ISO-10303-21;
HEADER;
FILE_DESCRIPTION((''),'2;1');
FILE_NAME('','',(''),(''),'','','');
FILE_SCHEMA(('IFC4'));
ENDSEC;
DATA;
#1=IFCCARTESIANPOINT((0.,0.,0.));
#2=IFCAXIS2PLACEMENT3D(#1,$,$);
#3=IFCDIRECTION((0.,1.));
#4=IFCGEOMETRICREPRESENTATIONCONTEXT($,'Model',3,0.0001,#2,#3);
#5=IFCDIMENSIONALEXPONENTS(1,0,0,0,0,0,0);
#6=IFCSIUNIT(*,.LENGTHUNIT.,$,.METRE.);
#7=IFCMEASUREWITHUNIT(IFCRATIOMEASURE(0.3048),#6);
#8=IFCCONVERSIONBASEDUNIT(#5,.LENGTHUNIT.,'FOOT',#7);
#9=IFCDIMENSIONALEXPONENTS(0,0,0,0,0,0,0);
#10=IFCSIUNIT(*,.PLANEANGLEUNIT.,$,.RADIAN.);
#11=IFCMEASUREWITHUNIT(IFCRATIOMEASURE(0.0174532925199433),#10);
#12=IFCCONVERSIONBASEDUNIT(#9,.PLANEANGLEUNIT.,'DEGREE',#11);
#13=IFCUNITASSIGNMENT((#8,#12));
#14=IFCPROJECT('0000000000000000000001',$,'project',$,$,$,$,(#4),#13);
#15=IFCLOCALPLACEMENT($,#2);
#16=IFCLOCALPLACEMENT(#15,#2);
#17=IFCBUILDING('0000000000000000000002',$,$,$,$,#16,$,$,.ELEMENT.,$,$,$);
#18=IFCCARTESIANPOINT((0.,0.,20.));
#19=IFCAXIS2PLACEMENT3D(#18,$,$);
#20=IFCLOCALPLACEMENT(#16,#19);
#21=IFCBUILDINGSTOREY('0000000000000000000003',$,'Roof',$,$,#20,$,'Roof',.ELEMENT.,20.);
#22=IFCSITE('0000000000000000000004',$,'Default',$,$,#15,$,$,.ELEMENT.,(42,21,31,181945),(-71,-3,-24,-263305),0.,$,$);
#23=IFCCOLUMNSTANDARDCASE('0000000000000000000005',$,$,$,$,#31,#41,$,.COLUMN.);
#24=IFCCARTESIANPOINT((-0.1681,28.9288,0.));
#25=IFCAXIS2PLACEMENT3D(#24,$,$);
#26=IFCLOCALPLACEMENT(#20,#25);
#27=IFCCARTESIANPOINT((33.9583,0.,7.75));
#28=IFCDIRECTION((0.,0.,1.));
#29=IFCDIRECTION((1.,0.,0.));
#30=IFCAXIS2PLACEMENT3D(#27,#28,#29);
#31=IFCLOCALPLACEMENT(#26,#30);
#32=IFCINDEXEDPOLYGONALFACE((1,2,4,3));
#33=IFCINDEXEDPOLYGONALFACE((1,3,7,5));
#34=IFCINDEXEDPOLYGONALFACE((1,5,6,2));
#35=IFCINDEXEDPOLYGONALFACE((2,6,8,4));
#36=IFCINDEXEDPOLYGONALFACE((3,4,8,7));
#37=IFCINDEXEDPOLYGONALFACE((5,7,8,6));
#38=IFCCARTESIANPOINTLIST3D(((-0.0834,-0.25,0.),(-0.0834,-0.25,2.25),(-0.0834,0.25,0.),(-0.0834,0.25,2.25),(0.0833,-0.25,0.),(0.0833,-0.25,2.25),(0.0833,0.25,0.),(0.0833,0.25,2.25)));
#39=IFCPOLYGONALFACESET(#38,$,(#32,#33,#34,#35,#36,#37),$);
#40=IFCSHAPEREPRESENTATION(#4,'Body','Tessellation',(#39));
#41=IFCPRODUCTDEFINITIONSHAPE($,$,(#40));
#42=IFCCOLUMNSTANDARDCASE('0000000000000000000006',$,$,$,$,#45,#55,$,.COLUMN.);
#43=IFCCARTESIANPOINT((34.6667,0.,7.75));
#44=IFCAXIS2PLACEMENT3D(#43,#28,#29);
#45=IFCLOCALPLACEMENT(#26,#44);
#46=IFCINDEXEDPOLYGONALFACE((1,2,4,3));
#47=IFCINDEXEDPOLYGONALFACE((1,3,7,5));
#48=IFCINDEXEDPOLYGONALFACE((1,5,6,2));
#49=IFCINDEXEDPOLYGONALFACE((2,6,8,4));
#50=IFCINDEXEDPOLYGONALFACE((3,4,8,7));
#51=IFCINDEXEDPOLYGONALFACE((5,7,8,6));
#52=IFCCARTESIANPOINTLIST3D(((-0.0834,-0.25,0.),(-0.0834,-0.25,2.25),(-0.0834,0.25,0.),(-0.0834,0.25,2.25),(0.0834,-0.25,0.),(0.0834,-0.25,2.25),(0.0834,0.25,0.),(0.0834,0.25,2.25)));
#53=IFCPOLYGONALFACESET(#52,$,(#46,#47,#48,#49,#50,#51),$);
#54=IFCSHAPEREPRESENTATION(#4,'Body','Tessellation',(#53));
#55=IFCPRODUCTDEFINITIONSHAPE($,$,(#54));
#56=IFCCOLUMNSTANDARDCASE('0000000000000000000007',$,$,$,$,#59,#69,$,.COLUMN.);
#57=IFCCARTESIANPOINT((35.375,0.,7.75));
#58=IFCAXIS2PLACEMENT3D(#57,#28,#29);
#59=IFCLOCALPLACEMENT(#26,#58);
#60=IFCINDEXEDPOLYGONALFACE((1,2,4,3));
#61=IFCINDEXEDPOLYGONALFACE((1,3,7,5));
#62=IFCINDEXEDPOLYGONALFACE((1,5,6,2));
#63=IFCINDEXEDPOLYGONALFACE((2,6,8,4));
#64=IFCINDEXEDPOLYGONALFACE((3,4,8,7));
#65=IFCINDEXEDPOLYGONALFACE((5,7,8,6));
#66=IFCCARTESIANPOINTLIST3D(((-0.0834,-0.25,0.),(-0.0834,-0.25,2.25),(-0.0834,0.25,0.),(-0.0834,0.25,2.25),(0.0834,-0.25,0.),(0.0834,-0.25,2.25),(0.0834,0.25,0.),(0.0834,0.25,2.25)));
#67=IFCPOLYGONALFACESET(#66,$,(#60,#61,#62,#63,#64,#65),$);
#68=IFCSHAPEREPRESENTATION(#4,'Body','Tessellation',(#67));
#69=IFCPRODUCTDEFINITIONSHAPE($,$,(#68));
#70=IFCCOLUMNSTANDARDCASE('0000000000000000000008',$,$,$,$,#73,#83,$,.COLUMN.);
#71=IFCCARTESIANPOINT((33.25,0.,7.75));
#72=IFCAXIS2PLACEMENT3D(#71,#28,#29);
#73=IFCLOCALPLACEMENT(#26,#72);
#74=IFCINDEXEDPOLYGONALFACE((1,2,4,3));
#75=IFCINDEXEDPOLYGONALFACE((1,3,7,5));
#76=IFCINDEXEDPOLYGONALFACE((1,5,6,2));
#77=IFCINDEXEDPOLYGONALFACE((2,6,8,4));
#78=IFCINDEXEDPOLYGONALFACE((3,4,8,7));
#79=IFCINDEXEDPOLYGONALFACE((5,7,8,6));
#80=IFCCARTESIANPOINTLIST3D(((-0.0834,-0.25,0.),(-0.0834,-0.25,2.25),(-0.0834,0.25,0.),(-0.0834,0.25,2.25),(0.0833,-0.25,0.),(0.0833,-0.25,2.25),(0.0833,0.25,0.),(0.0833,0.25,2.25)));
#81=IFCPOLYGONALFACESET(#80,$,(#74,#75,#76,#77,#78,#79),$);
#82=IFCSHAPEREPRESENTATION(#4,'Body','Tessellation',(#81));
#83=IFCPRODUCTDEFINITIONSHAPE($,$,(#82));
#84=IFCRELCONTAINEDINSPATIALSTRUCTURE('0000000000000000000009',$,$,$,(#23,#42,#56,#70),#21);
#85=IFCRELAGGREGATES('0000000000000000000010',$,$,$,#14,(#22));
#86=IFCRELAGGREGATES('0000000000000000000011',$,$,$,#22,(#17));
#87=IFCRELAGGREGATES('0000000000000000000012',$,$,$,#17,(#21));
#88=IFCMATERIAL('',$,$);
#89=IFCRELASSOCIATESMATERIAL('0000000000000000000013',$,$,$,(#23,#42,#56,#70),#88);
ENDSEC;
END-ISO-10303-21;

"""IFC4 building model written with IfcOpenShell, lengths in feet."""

from ifc_helpers import new_model, entity, si_unit, converted_unit, direction, frame, origin, place, context, project, spatial, rectangle, extrude, material, element, save


model = new_model("IFC4")

# Units and contexts
model_context = context("Model", 3, precision=0.0001, world=origin(), true_north=direction((0.0, 1.0)))
ifc_project = project(units=[converted_unit("LENGTHUNIT", "FOOT", entity("IfcRatioMeasure", 0.3048), si_unit("LENGTHUNIT", "METRE"), dimensions=[1, 0, 0, 0, 0, 0, 0]), converted_unit("PLANEANGLEUNIT", "DEGREE", entity("IfcRatioMeasure", 0.0174532925199433), si_unit("PLANEANGLEUNIT", "RADIAN"), dimensions=[0, 0, 0, 0, 0, 0, 0])], contexts=[model_context])

# Site, building, storey
site_placement = place(None, origin())
site = spatial("IfcSite", under=ifc_project, at=site_placement, Name="Default", CompositionType="ELEMENT", RefLatitude=(42, 21, 31, 181945), RefLongitude=(-71, -3, -24, -263305), RefElevation=0.0)
building_placement = place(site_placement, origin())
building = spatial("IfcBuilding", under=site, at=building_placement, CompositionType="ELEMENT")
storey_placement = place(building_placement, frame((0.0, 0.0, 20.0)))
storey = spatial("IfcBuildingStorey", under=building, at=storey_placement, Name="Roof", LongName="Roof", CompositionType="ELEMENT", Elevation=20.0)

# Columns
ifc_material_1 = material(Name="")
placement = place(storey_placement, frame((-0.1681, 28.9288, 0.0)))
for number, where, z_axis, x_axis in (
    (1, (33.9583, 0.0, 7.75), (0.0, 0.0, 1.0), (1.0, 0.0, 0.0)),
    (2, (34.6667, 0.0, 7.75), (0.0, 0.0, 1.0), (1.0, 0.0, 0.0)),
    (3, (35.375, 0.0, 7.75), (0.0, 0.0, 1.0), (1.0, 0.0, 0.0)),
    (4, (33.25, 0.0, 7.75), (0.0, 0.0, 1.0), (1.0, 0.0, 0.0)),
):
    element("IfcColumnStandardCase", number, at=place(placement, frame(where, z_axis=z_axis, x_axis=x_axis)), inside=storey, material=ifc_material_1, PredefinedType="COLUMN", context=model_context, shape_type="SweptSolid", body=[
        extrude(rectangle(XDim=0.1667, YDim=0.5), origin(), (0.0, 0.0, 1.0), 2.25),
    ])

save(model, "model.ifc")
